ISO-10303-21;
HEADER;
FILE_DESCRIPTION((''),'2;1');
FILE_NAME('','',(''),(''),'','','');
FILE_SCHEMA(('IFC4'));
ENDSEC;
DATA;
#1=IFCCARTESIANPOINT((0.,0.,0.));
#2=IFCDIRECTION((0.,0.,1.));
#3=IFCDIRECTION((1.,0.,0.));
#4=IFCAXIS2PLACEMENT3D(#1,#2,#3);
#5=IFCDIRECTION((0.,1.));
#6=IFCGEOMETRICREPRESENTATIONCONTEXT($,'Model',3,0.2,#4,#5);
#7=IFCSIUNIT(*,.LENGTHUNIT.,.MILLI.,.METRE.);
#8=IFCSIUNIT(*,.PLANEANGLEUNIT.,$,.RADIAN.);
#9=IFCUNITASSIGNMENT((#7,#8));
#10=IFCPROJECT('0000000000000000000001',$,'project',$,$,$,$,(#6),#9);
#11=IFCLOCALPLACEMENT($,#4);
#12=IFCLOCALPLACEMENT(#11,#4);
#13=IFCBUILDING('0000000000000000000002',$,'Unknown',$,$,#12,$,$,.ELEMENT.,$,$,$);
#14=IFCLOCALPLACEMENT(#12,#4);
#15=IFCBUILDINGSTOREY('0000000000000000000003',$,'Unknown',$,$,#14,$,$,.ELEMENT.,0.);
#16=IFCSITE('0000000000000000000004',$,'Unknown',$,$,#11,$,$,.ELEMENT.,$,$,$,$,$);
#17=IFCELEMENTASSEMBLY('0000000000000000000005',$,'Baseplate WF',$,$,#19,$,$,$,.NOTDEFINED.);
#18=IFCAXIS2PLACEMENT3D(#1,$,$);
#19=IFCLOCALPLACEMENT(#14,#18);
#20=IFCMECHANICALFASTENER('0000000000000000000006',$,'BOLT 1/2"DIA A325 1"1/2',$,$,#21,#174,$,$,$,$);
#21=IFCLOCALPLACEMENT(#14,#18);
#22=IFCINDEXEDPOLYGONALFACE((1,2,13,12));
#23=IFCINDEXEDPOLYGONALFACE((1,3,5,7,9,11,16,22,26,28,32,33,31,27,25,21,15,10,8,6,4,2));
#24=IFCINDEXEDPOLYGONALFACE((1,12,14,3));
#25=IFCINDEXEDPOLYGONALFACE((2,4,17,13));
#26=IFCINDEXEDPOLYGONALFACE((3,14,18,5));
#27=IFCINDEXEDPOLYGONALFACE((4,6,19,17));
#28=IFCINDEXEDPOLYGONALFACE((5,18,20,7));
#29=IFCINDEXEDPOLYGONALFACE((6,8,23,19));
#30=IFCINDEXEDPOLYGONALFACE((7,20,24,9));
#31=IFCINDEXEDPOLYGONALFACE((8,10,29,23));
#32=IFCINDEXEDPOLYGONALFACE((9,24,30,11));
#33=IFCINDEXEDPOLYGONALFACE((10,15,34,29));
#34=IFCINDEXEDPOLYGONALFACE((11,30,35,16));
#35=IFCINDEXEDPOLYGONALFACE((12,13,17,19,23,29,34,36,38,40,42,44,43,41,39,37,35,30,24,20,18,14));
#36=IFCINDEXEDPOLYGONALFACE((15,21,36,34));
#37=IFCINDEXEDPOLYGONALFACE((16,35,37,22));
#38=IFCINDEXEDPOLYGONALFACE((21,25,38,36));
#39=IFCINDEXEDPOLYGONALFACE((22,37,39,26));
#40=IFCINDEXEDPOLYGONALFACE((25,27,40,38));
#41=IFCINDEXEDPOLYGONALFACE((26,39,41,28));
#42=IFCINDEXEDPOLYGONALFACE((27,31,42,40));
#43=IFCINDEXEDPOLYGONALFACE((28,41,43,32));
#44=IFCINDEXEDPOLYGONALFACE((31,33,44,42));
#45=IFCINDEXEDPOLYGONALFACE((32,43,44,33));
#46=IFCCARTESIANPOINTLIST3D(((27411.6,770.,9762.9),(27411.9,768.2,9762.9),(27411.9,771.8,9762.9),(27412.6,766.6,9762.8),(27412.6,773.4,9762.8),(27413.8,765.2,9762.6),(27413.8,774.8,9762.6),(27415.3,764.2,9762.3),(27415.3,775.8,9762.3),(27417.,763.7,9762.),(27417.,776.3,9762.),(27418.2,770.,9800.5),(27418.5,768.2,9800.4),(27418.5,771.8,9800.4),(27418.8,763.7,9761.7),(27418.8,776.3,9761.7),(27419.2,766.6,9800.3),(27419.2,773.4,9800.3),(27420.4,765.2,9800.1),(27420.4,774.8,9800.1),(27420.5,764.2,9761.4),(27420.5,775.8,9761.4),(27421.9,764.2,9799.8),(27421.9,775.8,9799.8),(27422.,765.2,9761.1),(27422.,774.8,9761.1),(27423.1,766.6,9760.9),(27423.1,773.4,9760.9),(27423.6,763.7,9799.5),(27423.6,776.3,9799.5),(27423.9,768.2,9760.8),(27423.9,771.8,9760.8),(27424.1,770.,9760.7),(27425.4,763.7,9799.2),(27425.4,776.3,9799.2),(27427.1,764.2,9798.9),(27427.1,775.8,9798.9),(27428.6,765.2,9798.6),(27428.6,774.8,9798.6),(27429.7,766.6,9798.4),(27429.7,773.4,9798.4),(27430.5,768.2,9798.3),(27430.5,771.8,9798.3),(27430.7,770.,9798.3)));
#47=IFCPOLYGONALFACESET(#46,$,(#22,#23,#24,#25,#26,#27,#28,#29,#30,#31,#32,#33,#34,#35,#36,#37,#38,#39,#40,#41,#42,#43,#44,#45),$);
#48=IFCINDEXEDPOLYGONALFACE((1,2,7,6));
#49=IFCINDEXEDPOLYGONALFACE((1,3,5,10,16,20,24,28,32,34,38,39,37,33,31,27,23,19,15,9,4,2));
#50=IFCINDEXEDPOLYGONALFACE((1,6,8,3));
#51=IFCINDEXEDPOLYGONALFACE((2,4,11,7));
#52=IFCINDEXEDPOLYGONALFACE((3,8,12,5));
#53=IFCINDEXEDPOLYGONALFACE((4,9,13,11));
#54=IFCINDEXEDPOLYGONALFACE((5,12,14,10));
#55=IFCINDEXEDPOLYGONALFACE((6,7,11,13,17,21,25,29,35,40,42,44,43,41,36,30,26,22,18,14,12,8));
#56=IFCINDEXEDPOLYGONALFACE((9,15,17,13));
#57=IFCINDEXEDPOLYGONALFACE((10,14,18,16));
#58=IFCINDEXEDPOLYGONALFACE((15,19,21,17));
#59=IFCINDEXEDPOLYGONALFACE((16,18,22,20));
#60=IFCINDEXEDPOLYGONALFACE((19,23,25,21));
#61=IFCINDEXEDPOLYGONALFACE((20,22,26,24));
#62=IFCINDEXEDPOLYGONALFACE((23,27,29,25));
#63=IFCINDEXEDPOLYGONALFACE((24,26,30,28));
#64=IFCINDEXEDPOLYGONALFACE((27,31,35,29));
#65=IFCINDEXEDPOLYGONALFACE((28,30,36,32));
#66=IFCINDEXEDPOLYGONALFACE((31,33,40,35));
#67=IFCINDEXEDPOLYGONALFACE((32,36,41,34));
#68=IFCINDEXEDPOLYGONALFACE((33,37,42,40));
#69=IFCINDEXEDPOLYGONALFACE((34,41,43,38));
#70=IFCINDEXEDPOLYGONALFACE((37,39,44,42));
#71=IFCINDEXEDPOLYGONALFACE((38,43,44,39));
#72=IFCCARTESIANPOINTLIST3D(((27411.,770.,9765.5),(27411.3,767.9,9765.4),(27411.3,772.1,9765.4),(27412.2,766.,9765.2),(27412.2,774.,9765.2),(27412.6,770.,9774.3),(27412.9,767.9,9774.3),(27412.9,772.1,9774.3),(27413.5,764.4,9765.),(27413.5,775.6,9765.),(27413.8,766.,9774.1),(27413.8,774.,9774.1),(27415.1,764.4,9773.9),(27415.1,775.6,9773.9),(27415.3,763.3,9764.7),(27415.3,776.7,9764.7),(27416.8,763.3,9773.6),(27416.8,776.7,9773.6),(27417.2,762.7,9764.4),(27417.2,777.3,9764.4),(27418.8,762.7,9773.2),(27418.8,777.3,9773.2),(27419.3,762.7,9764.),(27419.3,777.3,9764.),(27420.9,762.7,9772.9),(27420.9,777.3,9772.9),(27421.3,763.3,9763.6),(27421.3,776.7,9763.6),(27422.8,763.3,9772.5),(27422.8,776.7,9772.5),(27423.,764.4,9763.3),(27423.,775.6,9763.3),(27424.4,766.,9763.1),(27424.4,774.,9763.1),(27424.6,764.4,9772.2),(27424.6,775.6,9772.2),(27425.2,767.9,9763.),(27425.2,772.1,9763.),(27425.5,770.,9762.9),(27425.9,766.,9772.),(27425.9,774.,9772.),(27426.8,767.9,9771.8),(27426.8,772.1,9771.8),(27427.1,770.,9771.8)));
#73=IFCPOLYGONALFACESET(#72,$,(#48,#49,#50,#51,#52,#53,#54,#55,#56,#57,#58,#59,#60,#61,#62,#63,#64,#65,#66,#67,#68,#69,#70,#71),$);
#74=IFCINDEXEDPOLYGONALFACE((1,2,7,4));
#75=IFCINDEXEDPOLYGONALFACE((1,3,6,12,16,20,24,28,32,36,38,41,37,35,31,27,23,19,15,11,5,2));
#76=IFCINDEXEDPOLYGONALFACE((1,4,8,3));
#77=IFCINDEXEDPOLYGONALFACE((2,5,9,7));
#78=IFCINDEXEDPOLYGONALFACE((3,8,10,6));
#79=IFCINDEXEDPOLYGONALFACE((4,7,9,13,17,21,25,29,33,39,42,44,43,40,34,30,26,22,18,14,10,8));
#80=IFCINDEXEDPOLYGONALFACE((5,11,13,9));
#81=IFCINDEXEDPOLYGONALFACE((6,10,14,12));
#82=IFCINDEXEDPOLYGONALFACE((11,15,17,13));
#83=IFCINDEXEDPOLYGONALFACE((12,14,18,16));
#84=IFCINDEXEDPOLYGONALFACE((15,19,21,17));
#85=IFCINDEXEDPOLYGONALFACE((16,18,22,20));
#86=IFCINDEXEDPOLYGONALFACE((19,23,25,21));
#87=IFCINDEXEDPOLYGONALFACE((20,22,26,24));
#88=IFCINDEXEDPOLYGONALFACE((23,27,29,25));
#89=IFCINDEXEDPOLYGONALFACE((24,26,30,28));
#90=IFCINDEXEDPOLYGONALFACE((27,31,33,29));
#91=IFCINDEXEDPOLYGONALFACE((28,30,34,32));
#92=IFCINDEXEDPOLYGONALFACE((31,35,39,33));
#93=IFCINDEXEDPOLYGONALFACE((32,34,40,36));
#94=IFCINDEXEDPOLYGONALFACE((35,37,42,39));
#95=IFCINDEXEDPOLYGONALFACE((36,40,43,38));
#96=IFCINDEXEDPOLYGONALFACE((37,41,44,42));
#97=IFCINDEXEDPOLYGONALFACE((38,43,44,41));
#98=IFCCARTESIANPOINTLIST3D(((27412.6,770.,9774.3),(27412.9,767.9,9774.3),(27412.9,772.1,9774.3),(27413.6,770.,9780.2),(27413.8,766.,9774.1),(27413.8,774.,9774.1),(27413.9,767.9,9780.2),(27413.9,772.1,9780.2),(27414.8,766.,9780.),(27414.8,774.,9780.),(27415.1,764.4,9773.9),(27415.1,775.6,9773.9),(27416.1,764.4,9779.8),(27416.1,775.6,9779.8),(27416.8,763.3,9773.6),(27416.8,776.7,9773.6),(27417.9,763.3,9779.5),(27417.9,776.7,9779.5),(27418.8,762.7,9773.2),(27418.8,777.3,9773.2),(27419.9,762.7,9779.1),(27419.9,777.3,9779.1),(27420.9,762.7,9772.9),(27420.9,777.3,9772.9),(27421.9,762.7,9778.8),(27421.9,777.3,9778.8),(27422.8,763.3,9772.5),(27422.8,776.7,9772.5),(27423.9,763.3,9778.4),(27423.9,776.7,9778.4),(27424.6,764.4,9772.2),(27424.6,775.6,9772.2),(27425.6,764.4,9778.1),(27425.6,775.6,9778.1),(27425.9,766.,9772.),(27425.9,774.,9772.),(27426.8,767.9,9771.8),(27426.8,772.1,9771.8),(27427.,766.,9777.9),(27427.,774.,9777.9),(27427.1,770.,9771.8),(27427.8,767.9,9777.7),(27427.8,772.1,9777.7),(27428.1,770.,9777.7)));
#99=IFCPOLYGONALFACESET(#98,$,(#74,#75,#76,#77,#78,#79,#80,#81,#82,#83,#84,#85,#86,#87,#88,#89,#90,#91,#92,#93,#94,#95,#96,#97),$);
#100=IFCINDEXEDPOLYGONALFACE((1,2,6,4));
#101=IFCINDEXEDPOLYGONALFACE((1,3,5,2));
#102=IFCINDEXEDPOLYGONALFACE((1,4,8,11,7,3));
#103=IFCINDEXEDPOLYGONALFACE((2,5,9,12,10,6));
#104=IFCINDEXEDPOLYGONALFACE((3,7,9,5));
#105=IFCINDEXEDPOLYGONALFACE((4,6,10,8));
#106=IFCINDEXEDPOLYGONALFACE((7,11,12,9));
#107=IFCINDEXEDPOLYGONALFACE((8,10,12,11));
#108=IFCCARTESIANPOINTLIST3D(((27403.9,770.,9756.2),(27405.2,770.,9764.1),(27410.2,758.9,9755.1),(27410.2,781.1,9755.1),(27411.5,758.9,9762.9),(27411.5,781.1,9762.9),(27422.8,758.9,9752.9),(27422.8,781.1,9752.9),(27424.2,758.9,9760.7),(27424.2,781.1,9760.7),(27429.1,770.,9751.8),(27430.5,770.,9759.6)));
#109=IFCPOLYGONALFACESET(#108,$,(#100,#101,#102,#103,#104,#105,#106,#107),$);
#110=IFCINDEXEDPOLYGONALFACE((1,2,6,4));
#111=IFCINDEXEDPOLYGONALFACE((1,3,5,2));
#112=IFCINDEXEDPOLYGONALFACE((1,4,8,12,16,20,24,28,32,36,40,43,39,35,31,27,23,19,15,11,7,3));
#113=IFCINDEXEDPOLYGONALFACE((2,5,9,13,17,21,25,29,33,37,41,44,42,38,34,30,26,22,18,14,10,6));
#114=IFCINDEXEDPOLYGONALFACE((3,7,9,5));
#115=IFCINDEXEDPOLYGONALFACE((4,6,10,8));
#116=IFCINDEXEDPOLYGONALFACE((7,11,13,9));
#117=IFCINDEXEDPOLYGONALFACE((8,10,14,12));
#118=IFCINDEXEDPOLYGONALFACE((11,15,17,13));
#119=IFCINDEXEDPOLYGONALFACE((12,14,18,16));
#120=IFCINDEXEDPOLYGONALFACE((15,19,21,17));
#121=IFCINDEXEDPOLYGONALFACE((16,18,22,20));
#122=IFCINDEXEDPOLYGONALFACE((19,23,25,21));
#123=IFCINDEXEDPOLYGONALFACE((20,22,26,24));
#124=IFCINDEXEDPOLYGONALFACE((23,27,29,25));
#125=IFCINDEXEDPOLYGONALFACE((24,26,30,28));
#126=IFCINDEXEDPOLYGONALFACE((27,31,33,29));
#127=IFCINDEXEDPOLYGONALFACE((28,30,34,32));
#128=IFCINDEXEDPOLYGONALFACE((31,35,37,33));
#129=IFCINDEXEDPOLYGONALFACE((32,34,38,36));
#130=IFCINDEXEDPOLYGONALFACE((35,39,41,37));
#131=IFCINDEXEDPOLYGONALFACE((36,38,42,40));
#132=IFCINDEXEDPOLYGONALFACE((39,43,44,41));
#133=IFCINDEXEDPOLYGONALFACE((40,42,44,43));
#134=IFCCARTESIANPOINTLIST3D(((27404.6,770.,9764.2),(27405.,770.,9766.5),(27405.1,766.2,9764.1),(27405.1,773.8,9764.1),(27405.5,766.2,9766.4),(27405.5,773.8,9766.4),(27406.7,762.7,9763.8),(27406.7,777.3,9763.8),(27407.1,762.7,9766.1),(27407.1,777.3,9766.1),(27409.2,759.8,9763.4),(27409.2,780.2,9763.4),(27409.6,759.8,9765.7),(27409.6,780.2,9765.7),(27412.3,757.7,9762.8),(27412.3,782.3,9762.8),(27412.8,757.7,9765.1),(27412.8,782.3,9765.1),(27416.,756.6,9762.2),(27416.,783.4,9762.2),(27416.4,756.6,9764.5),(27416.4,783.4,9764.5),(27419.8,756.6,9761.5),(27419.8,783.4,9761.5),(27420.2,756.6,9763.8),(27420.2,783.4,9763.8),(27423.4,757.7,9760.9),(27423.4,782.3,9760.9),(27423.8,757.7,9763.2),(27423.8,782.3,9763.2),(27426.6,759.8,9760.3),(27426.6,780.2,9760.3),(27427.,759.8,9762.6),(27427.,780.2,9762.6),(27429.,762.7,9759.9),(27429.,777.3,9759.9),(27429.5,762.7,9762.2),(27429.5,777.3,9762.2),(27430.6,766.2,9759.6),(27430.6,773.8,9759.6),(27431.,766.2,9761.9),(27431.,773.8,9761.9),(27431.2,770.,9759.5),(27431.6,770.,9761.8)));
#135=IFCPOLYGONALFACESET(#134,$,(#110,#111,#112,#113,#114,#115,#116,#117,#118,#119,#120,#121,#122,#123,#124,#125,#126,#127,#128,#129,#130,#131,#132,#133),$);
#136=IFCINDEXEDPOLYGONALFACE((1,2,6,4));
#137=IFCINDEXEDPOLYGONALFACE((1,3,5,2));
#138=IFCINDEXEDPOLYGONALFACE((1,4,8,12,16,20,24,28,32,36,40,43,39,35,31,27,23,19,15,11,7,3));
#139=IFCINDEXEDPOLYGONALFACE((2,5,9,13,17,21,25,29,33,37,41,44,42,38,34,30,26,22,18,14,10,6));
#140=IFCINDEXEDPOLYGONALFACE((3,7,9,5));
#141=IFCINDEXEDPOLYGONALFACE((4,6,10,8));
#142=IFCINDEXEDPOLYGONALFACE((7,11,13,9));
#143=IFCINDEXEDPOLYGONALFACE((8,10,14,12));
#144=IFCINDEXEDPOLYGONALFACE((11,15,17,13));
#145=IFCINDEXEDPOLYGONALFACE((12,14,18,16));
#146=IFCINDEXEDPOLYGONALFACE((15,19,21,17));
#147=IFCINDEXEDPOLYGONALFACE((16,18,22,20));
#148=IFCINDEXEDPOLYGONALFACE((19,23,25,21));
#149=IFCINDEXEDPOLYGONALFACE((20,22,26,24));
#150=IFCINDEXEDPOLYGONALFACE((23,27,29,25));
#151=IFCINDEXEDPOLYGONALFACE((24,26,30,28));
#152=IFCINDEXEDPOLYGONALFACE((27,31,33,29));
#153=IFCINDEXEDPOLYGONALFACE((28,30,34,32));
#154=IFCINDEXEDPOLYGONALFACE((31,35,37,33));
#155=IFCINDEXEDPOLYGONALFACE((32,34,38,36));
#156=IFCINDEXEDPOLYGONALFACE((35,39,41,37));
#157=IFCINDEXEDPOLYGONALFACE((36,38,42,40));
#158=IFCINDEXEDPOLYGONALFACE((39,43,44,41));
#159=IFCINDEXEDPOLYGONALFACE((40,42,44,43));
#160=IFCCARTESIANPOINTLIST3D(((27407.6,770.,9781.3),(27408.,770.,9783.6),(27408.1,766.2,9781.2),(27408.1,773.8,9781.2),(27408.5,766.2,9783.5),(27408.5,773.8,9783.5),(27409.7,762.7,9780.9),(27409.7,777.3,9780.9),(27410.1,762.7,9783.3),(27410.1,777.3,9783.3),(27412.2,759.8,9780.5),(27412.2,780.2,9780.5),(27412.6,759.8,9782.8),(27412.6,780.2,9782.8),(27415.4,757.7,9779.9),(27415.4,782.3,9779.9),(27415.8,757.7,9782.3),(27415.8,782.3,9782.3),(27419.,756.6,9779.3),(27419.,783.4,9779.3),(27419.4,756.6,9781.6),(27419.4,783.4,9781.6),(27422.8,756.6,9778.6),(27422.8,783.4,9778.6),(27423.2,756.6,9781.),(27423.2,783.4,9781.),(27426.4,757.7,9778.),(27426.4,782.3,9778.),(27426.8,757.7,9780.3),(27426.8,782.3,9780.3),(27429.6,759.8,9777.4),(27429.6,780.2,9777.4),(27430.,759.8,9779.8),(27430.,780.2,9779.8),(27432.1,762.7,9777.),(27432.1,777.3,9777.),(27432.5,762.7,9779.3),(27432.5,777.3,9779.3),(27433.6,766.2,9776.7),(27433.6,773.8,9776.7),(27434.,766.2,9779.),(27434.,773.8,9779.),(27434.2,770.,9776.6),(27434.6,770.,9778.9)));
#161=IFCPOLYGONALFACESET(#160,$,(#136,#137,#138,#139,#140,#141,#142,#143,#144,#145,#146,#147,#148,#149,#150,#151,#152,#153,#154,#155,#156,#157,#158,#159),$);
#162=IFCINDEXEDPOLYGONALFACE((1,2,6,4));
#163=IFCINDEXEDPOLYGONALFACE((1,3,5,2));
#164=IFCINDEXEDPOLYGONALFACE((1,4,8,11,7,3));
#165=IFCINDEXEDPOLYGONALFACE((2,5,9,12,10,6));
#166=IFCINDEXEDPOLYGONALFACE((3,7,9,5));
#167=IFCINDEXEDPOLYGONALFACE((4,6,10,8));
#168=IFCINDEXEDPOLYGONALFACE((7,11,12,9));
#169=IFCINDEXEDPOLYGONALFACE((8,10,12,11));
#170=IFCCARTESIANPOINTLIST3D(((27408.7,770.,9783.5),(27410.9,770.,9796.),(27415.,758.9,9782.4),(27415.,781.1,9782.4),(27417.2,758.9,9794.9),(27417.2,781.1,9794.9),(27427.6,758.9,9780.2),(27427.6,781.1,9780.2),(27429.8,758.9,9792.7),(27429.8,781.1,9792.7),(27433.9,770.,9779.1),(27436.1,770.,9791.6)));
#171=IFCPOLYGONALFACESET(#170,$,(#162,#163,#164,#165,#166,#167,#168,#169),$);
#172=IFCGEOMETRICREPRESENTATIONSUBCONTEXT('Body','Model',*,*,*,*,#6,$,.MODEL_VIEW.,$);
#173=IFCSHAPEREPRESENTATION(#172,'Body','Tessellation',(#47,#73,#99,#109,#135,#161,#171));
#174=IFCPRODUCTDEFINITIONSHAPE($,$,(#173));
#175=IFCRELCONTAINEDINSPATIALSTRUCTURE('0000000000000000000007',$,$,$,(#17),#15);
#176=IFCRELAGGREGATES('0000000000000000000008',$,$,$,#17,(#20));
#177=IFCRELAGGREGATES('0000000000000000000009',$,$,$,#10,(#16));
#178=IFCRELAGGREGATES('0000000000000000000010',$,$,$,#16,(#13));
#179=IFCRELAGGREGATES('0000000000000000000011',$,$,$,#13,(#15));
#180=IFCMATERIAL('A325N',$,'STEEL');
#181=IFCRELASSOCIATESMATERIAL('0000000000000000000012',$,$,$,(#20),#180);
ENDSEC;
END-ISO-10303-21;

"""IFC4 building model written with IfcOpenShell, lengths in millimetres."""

from ifc_helpers import new_model, si_unit, direction, frame, origin_with_axes, place, context, subcontext, project, spatial, line, arc, indexed_curve, outline, extrude, source, transform, mapped, material, element, aggregate, save


model = new_model("IFC4")

# Units and contexts
model_context = context("Model", 3, precision=0.2, world=origin_with_axes(), true_north=direction((0.0, 1.0)))
body_context = subcontext(model_context, "Body", "Model", "MODEL_VIEW")
ifc_project = project(units=[si_unit("LENGTHUNIT", "METRE", prefix="MILLI"), si_unit("PLANEANGLEUNIT", "RADIAN")], contexts=[model_context])

# Site, building, storey
site_placement = place(None, origin_with_axes())
site = spatial("IfcSite", under=ifc_project, at=site_placement, Name="Unknown", CompositionType="ELEMENT")
building_placement = place(site_placement, origin_with_axes())
building = spatial("IfcBuilding", under=site, at=building_placement, Name="Unknown", CompositionType="ELEMENT")
storey_placement = place(building_placement, origin_with_axes())
storey = spatial("IfcBuildingStorey", under=building, at=storey_placement, Name="Unknown", CompositionType="ELEMENT", Elevation=0.0)

# Element assembly
assembly_1_placement = place(storey_placement, frame((27449.9, 800.0, 9770.8), z_axis=(-0.173648, 0.0, -0.984808), x_axis=(0.0, -1.0, 0.0)))
assembly_1 = element("IfcElementAssembly", 1, at=assembly_1_placement, inside=storey, Name="Baseplate WF", PredefinedType="NOTDEFINED")

# Mechanical fastener
ifc_material_1 = material(Name="A325N", Category="STEEL")
shared_shape = source(origin_with_axes(), body_context, "Body", "SweptSolid", [
    extrude(outline(indexed_curve([(6.3, 0.0), (0.0, 6.3), (-6.3, 0.0), (0.0, -6.3)], segments=[arc(1, 2, 3), arc(3, 4, 1)])), frame((0.0, 0.0, 17.4), z_axis=(0.0, 0.0, -1.0), x_axis=(0.0, 1.0, 0.0)), (0.0, 0.0, 1.0), 38.1),
    extrude(outline(indexed_curve([(7.3, 0.0), (0.0, 7.3), (-7.3, 0.0), (0.0, -7.3)], segments=[arc(1, 2, 3), arc(3, 4, 1)])), frame((0.0, 0.0, 15.0), z_axis=(0.0, 0.0, -1.0), x_axis=(0.0, 1.0, 0.0)), (0.0, 0.0, 1.0), 9.0),
    extrude(outline(indexed_curve([(7.3, 0.0), (0.0, 7.3), (-7.3, 0.0), (0.0, -7.3)], segments=[arc(1, 2, 3), arc(3, 4, 1)])), frame((0.0, 0.0, 6.0), z_axis=(0.0, 0.0, -1.0), x_axis=(0.0, 1.0, 0.0)), (0.0, 0.0, 1.0), 6.0),
    extrude(outline(indexed_curve([(12.8, 0.0), (6.4, 11.1), (-6.4, 11.1), (-12.8, 0.0), (-6.4, -11.1), (6.4, -11.1)], segments=[line(1, 2, 3, 4, 5, 6, 1)])), frame((0.0, 0.0, 25.3), z_axis=(0.0, 0.0, -1.0), x_axis=(0.0, 1.0, 0.0)), (0.0, 0.0, 1.0), 7.9),
    extrude(outline(indexed_curve([(13.5, 0.0), (0.0, 13.5), (-13.5, 0.0), (0.0, -13.5)], segments=[arc(1, 2, 3), arc(3, 4, 1)])), frame((0.0, 0.0, 17.4), z_axis=(0.0, 0.0, -1.0), x_axis=(0.0, 1.0, 0.0)), (0.0, 0.0, 1.0), 2.4),
    extrude(outline(indexed_curve([(13.5, 0.0), (0.0, 13.5), (-13.5, 0.0), (0.0, -13.5)], segments=[arc(1, 2, 3), arc(3, 4, 1)])), frame((0.0, 0.0, 0.0), z_axis=(0.0, 0.0, -1.0), x_axis=(0.0, 1.0, 0.0)), (0.0, 0.0, 1.0), 2.4),
    extrude(outline(indexed_curve([(12.8, 0.0), (6.4, 11.1), (-6.4, 11.1), (-12.8, 0.0), (-6.4, -11.1), (6.4, -11.1)], segments=[line(1, 2, 3, 4, 5, 6, 1)])), frame((0.0, 0.0, -2.4), z_axis=(0.0, 0.0, -1.0), x_axis=(0.0, 1.0, 0.0)), (0.0, 0.0, 1.0), 12.7),
])
mechanical_fastener_1_placement = place(assembly_1_placement, frame((30.0, 30.0, -3.0), z_axis=(0.0, 0.0, 1.0), x_axis=(1.0, 0.0, 0.0)))
mechanical_fastener_1 = element("IfcMechanicalFastener", 2, at=mechanical_fastener_1_placement, material=ifc_material_1, Name="BOLT 1/2\"DIA A325 1\"1/2", context=body_context, shape_type="MappedRepresentation", body=[
    mapped(shared_shape, transform((0.0, 0.0, 0.0))),
])
aggregate(assembly_1, [mechanical_fastener_1])

save(model, "model.ifc")
